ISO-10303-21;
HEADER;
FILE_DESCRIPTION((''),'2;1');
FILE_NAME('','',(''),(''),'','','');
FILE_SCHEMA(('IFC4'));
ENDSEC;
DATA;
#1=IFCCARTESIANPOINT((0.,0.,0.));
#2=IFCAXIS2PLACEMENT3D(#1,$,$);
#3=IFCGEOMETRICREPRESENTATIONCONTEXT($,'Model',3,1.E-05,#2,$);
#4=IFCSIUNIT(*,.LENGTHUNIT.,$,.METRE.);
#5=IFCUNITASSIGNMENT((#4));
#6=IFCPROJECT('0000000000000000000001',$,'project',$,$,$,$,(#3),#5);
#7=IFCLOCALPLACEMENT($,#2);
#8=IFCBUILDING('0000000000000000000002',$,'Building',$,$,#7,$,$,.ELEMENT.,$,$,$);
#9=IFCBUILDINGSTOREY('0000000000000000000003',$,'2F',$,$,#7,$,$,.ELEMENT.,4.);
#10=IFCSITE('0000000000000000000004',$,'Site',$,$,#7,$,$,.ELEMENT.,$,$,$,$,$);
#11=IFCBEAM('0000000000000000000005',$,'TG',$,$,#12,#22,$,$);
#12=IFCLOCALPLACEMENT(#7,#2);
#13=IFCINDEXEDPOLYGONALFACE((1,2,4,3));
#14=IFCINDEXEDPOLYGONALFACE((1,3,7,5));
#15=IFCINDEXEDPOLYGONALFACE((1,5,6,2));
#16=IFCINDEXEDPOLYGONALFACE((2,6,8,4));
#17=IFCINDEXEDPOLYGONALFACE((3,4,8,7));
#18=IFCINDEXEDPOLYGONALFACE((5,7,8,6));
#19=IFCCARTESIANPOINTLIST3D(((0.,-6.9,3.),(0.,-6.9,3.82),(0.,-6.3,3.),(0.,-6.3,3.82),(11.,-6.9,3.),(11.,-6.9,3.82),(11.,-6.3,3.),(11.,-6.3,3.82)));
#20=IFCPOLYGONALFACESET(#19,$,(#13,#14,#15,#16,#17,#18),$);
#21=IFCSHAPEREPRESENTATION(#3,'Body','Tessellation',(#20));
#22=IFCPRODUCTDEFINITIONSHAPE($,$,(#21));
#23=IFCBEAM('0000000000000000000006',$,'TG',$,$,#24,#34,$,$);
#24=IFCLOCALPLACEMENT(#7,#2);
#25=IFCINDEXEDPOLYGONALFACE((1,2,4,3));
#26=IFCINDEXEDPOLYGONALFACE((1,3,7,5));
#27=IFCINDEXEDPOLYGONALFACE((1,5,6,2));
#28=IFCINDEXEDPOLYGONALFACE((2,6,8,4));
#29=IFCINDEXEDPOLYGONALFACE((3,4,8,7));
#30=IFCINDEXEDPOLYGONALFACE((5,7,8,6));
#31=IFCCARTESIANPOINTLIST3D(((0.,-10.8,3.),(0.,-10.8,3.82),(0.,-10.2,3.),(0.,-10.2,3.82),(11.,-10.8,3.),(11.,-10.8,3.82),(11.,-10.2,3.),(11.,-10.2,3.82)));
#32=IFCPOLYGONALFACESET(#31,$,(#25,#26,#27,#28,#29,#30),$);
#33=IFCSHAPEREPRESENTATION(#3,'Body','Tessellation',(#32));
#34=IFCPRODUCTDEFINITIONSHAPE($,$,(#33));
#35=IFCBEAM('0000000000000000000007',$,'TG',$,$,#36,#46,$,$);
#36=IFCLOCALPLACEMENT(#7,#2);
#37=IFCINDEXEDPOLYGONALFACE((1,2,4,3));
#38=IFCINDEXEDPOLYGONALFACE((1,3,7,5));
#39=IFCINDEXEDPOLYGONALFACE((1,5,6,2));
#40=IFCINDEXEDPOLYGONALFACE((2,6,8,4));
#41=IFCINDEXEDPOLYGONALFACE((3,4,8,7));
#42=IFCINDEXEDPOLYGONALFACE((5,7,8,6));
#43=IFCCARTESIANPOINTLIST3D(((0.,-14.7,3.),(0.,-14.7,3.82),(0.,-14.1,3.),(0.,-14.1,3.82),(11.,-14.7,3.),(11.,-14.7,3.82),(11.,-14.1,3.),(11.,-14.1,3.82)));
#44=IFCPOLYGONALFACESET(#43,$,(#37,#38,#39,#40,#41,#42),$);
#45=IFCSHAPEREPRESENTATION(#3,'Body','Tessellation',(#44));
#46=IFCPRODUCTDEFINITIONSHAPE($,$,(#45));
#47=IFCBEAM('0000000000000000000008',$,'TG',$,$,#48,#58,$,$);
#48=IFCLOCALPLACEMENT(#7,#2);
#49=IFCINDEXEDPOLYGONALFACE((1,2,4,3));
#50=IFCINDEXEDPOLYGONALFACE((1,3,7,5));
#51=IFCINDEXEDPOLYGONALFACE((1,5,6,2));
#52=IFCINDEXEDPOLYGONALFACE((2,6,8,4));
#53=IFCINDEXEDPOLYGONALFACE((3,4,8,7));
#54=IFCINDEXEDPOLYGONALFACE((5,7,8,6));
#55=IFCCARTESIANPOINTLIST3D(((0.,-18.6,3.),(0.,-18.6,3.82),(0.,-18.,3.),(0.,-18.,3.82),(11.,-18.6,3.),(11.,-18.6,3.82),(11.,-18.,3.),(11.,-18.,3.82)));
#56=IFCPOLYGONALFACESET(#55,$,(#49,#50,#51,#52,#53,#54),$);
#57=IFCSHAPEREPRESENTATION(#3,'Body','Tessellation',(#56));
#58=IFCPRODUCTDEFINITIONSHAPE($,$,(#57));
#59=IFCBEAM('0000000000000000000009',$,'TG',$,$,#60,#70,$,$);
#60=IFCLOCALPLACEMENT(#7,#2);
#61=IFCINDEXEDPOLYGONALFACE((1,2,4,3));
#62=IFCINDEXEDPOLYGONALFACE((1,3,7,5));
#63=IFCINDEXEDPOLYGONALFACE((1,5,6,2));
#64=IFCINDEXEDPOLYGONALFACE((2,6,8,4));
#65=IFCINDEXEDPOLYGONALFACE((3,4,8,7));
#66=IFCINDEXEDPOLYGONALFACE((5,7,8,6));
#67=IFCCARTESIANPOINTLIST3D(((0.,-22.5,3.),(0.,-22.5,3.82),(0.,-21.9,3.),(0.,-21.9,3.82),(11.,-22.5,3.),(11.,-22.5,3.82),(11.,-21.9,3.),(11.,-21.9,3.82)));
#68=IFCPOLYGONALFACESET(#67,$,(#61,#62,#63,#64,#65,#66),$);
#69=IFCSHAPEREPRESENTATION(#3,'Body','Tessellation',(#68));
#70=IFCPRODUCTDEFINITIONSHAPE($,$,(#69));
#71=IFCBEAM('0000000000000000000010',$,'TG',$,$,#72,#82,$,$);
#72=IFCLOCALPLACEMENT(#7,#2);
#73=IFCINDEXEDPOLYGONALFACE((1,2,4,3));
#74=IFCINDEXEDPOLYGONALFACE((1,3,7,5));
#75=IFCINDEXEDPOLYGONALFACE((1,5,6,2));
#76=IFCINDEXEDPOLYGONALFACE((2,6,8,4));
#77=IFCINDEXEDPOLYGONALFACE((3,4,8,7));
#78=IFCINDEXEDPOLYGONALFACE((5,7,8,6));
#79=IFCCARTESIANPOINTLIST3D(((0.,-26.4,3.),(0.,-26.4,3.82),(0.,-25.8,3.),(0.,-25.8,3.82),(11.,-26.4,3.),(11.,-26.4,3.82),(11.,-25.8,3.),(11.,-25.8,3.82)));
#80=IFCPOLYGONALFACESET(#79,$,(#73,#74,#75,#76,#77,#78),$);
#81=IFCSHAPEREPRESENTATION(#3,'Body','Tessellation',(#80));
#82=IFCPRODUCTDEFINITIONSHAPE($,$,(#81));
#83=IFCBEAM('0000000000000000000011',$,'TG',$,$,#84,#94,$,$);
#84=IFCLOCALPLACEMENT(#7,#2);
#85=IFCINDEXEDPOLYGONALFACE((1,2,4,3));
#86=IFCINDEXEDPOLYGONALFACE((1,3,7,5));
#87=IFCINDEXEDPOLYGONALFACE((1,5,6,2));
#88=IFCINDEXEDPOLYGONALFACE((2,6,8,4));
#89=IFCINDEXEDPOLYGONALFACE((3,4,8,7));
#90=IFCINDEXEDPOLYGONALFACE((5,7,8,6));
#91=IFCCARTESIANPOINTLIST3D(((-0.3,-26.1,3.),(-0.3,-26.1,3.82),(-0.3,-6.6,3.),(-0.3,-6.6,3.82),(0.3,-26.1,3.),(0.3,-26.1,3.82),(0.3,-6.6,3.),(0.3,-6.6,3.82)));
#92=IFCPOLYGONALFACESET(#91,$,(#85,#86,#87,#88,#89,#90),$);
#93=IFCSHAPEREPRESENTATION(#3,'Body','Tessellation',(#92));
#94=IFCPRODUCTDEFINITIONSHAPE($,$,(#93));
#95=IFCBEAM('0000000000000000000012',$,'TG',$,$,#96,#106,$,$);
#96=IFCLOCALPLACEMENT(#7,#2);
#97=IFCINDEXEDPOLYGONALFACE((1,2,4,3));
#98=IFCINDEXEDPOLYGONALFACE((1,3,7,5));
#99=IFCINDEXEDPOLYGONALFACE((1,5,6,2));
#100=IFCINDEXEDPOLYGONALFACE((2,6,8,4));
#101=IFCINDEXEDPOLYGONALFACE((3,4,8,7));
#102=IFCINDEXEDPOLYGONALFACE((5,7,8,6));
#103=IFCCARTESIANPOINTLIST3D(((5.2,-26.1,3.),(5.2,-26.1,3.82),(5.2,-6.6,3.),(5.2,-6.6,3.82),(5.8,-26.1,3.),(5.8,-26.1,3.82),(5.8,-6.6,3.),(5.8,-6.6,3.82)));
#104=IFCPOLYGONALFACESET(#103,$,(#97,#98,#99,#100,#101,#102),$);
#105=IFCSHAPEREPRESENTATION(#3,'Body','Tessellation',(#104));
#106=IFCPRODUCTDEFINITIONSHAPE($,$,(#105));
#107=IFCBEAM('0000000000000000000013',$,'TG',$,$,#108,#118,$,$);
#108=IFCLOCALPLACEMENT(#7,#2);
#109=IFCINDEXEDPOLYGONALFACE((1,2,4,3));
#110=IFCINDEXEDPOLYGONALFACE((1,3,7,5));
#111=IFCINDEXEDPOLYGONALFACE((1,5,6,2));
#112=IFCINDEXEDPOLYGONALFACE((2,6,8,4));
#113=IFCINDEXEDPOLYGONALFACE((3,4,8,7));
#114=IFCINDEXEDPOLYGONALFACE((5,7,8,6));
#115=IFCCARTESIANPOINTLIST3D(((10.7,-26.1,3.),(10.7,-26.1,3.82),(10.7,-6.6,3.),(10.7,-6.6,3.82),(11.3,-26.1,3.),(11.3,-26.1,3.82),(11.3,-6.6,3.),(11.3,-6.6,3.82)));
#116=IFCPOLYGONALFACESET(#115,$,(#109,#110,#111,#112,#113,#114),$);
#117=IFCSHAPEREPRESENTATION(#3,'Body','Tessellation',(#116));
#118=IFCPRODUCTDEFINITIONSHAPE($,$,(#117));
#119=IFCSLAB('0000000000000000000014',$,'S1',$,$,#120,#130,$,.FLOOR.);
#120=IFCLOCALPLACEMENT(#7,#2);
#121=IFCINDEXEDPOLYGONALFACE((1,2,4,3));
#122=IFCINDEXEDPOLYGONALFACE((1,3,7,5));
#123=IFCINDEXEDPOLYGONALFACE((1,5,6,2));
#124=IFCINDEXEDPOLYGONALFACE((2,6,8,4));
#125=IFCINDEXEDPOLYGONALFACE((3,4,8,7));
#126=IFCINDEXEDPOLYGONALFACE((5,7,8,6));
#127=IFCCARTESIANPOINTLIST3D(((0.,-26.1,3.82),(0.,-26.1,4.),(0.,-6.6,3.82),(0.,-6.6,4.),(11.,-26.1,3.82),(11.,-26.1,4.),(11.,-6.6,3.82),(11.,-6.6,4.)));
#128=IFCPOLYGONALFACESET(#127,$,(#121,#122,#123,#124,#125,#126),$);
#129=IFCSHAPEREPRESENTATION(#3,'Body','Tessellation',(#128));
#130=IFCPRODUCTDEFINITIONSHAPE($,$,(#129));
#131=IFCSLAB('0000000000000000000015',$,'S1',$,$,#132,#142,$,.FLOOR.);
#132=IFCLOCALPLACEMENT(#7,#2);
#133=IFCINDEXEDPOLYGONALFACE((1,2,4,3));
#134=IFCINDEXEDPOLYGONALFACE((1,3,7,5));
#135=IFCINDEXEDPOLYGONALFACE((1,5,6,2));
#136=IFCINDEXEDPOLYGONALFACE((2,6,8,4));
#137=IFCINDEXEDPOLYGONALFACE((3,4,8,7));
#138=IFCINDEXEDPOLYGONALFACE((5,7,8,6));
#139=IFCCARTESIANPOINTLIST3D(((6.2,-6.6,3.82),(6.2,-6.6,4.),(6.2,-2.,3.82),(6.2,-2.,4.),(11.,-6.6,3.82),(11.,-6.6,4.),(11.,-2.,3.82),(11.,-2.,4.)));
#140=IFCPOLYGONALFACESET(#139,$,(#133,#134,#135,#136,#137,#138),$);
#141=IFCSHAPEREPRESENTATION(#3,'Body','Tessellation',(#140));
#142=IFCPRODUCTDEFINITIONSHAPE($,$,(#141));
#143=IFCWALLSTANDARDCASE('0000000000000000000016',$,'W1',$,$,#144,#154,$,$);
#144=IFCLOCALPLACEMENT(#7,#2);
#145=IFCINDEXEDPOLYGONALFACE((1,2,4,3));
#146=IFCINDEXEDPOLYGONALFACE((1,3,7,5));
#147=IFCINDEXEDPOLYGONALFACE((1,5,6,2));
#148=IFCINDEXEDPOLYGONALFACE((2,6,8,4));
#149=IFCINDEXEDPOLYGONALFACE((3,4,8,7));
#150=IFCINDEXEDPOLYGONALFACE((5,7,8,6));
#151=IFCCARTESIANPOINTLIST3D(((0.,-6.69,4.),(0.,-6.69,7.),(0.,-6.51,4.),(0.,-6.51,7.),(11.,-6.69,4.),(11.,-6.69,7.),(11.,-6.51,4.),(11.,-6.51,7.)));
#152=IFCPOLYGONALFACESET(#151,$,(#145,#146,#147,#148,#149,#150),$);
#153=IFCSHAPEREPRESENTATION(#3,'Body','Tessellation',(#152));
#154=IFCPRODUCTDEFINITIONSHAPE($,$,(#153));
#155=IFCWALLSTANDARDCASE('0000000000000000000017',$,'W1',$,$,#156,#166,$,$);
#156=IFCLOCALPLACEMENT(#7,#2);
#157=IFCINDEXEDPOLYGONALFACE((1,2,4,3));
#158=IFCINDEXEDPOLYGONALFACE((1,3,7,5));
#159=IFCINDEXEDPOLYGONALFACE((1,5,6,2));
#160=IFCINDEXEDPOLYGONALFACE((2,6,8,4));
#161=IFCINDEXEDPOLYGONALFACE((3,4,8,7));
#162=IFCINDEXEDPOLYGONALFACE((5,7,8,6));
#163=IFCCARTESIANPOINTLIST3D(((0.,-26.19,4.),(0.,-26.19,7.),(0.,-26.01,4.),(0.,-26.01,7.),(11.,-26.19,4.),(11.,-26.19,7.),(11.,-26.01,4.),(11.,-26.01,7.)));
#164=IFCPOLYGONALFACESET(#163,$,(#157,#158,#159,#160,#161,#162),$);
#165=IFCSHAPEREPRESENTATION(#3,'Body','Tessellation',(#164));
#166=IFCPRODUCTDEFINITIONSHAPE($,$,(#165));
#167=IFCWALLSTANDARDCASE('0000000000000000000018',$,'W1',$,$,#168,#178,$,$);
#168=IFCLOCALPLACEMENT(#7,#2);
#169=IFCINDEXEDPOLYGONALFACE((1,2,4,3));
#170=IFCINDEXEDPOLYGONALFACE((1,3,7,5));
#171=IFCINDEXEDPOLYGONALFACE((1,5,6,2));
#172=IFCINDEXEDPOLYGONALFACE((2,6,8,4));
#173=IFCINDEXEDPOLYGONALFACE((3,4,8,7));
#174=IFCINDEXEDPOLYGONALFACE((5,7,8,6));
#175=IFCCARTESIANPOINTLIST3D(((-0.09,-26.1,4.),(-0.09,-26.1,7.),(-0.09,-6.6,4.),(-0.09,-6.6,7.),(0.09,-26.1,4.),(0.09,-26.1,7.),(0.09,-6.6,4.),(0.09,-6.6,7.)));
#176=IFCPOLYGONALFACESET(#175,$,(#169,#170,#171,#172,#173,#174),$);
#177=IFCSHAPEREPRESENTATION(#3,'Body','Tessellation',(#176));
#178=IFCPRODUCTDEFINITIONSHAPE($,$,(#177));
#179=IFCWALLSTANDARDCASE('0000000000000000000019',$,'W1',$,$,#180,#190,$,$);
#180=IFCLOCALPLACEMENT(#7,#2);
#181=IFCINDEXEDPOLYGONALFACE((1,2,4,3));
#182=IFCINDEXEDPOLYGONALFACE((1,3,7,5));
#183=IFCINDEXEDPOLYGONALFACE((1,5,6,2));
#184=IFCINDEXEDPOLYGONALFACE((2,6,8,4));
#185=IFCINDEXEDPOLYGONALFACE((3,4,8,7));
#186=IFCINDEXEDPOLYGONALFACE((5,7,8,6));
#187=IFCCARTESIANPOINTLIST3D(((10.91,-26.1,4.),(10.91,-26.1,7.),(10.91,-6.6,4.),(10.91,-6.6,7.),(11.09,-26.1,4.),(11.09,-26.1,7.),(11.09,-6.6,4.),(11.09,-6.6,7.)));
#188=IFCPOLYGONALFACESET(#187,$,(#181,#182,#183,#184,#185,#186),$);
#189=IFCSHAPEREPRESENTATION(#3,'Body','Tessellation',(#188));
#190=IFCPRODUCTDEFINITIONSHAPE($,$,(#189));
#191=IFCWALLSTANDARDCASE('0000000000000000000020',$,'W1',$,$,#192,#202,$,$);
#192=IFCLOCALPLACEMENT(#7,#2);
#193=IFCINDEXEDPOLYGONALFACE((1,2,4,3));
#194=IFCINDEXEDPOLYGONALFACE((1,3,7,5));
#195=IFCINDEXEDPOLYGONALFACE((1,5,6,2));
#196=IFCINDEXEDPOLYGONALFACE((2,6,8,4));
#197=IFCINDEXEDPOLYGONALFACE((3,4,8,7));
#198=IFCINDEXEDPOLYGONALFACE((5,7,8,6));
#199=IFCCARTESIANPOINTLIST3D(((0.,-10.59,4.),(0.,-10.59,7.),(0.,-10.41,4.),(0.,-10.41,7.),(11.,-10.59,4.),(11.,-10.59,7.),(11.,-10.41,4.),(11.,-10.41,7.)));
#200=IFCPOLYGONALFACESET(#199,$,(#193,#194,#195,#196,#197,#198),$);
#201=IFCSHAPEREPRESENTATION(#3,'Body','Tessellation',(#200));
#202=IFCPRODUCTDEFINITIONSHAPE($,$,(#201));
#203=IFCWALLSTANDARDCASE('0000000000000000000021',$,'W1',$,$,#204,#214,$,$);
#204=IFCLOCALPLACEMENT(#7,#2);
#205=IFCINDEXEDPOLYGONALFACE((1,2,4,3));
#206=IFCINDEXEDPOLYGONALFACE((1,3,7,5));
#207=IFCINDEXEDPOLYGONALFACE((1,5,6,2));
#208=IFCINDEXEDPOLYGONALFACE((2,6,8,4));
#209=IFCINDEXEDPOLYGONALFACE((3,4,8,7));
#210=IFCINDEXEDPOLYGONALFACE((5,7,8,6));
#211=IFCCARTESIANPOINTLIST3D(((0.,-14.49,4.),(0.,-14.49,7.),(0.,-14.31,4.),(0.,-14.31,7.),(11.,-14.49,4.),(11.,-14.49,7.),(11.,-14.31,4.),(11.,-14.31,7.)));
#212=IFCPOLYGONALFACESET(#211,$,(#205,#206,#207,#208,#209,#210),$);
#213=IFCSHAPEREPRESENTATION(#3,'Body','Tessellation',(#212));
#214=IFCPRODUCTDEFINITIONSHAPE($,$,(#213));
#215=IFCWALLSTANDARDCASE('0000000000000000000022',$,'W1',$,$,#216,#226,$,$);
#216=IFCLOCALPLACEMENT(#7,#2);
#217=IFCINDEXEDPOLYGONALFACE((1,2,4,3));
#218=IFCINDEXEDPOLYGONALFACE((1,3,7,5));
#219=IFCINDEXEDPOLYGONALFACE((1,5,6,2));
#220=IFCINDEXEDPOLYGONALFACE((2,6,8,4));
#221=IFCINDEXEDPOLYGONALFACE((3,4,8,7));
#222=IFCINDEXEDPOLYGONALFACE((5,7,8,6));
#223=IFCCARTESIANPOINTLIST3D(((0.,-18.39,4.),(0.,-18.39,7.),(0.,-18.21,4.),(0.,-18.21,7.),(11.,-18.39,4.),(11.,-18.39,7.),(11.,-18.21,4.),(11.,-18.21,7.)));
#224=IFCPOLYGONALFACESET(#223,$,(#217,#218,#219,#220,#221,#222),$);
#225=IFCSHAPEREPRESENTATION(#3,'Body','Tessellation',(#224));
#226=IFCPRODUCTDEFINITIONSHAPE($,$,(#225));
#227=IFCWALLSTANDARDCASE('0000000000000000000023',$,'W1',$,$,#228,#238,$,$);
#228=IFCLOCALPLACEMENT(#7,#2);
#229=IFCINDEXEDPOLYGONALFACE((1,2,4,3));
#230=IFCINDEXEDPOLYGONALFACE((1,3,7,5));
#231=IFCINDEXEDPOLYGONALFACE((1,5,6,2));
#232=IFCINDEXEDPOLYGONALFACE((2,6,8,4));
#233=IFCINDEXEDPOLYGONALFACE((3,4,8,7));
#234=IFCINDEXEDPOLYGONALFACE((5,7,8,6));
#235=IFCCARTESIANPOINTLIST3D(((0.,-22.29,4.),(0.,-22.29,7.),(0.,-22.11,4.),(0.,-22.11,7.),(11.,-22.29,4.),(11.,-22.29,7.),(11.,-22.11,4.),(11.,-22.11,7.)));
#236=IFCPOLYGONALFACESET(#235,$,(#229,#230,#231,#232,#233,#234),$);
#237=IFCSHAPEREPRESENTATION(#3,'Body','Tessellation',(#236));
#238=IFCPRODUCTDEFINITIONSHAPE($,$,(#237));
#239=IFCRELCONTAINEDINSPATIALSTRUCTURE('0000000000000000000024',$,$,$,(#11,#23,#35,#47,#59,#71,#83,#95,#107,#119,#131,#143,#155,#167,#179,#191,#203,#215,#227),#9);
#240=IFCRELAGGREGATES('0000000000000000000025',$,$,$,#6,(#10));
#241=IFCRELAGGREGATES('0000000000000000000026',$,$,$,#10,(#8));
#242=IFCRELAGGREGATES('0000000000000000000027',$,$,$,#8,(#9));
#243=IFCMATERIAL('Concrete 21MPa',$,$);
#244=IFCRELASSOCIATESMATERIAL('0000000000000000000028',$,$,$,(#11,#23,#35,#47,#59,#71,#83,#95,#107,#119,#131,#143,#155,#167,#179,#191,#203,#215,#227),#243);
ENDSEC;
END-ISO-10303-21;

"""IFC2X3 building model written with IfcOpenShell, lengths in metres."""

from ifc_helpers import new_model, si_unit, frame, origin, origin_2d, place, context, project, spatial, rectangle, extrude, material, element, save


model = new_model("IFC2X3")

# Units and contexts
model_context = context("Model", 3, precision=1e-05, world=origin())
ifc_project = project(units=[si_unit("LENGTHUNIT", "METRE")], contexts=[model_context])

# Site, building, storey
placement = place(None, origin())
site = spatial("IfcSite", under=ifc_project, at=placement, Name="Site", CompositionType="ELEMENT")
building = spatial("IfcBuilding", under=site, at=placement, Name="Building", CompositionType="ELEMENT")
storey = spatial("IfcBuildingStorey", under=building, at=placement, Name="2F", CompositionType="ELEMENT", Elevation=4.0)

# Beams
ifc_material_1 = material(Name="Concrete 21MPa")
for number, where, name in (
    (1, (5.5, -6.6, 3.0), "TG"),
    (2, (5.5, -10.5, 3.0), "TG"),
    (3, (5.5, -14.4, 3.0), "TG"),
    (4, (5.5, -18.3, 3.0), "TG"),
    (5, (5.5, -22.2, 3.0), "TG"),
    (6, (5.5, -26.1, 3.0), "TG"),
):
    element("IfcBeam", number, at=place(None, frame(where)), inside=storey, material=ifc_material_1, Name=name, context=model_context, shape_type="SweptSolid", body=[
        extrude(rectangle(XDim=11.0, YDim=0.6, at=origin_2d()), origin(), (0.0, 0.0, 1.0), 0.82),
    ])
for number, where, name in (
    (7, (0.0, -16.35, 3.0), "TG"),
    (8, (5.5, -16.35, 3.0), "TG"),
    (9, (11.0, -16.35, 3.0), "TG"),
):
    element("IfcBeam", number, at=place(None, frame(where)), inside=storey, material=ifc_material_1, Name=name, context=model_context, shape_type="SweptSolid", body=[
        extrude(rectangle(XDim=0.6, YDim=19.5, at=origin_2d()), origin(), (0.0, 0.0, 1.0), 0.82),
    ])

# Slabs
slab_1_placement = place(None, frame((5.5, -16.35, 3.82)))
element("IfcSlab", 10, at=slab_1_placement, inside=storey, material=ifc_material_1, Name="S1", PredefinedType="FLOOR", context=model_context, shape_type="SweptSolid", body=[
    extrude(rectangle(XDim=11.0, YDim=19.5, at=origin_2d()), origin(), (0.0, 0.0, 1.0), 0.18),
])
slab_2_placement = place(None, frame((8.6, -4.3, 3.82)))
element("IfcSlab", 11, at=slab_2_placement, inside=storey, material=ifc_material_1, Name="S1", PredefinedType="FLOOR", context=model_context, shape_type="SweptSolid", body=[
    extrude(rectangle(XDim=4.8, YDim=4.6, at=origin_2d()), origin(), (0.0, 0.0, 1.0), 0.18),
])

# Walls
for number, where, name in (
    (12, (5.5, -6.6, 4.0), "W1"),
    (13, (5.5, -26.1, 4.0), "W1"),
):
    element("IfcWallStandardCase", number, at=place(None, frame(where)), inside=storey, material=ifc_material_1, Name=name, context=model_context, shape_type="SweptSolid", body=[
        extrude(rectangle(XDim=11.0, YDim=0.18, at=origin_2d()), origin(), (0.0, 0.0, 1.0), 3.0),
    ])
for number, where, name in (
    (14, (0.0, -16.35, 4.0), "W1"),
    (15, (11.0, -16.35, 4.0), "W1"),
):
    element("IfcWallStandardCase", number, at=place(None, frame(where)), inside=storey, material=ifc_material_1, Name=name, context=model_context, shape_type="SweptSolid", body=[
        extrude(rectangle(XDim=0.18, YDim=19.5, at=origin_2d()), origin(), (0.0, 0.0, 1.0), 3.0),
    ])
for number, where, name in (
    (16, (5.5, -10.5, 4.0), "W1"),
    (17, (5.5, -14.4, 4.0), "W1"),
    (18, (5.5, -18.3, 4.0), "W1"),
    (19, (5.5, -22.2, 4.0), "W1"),
):
    element("IfcWallStandardCase", number, at=place(None, frame(where)), inside=storey, material=ifc_material_1, Name=name, context=model_context, shape_type="SweptSolid", body=[
        extrude(rectangle(XDim=11.0, YDim=0.18, at=origin_2d()), origin(), (0.0, 0.0, 1.0), 3.0),
    ])

save(model, "model.ifc")
